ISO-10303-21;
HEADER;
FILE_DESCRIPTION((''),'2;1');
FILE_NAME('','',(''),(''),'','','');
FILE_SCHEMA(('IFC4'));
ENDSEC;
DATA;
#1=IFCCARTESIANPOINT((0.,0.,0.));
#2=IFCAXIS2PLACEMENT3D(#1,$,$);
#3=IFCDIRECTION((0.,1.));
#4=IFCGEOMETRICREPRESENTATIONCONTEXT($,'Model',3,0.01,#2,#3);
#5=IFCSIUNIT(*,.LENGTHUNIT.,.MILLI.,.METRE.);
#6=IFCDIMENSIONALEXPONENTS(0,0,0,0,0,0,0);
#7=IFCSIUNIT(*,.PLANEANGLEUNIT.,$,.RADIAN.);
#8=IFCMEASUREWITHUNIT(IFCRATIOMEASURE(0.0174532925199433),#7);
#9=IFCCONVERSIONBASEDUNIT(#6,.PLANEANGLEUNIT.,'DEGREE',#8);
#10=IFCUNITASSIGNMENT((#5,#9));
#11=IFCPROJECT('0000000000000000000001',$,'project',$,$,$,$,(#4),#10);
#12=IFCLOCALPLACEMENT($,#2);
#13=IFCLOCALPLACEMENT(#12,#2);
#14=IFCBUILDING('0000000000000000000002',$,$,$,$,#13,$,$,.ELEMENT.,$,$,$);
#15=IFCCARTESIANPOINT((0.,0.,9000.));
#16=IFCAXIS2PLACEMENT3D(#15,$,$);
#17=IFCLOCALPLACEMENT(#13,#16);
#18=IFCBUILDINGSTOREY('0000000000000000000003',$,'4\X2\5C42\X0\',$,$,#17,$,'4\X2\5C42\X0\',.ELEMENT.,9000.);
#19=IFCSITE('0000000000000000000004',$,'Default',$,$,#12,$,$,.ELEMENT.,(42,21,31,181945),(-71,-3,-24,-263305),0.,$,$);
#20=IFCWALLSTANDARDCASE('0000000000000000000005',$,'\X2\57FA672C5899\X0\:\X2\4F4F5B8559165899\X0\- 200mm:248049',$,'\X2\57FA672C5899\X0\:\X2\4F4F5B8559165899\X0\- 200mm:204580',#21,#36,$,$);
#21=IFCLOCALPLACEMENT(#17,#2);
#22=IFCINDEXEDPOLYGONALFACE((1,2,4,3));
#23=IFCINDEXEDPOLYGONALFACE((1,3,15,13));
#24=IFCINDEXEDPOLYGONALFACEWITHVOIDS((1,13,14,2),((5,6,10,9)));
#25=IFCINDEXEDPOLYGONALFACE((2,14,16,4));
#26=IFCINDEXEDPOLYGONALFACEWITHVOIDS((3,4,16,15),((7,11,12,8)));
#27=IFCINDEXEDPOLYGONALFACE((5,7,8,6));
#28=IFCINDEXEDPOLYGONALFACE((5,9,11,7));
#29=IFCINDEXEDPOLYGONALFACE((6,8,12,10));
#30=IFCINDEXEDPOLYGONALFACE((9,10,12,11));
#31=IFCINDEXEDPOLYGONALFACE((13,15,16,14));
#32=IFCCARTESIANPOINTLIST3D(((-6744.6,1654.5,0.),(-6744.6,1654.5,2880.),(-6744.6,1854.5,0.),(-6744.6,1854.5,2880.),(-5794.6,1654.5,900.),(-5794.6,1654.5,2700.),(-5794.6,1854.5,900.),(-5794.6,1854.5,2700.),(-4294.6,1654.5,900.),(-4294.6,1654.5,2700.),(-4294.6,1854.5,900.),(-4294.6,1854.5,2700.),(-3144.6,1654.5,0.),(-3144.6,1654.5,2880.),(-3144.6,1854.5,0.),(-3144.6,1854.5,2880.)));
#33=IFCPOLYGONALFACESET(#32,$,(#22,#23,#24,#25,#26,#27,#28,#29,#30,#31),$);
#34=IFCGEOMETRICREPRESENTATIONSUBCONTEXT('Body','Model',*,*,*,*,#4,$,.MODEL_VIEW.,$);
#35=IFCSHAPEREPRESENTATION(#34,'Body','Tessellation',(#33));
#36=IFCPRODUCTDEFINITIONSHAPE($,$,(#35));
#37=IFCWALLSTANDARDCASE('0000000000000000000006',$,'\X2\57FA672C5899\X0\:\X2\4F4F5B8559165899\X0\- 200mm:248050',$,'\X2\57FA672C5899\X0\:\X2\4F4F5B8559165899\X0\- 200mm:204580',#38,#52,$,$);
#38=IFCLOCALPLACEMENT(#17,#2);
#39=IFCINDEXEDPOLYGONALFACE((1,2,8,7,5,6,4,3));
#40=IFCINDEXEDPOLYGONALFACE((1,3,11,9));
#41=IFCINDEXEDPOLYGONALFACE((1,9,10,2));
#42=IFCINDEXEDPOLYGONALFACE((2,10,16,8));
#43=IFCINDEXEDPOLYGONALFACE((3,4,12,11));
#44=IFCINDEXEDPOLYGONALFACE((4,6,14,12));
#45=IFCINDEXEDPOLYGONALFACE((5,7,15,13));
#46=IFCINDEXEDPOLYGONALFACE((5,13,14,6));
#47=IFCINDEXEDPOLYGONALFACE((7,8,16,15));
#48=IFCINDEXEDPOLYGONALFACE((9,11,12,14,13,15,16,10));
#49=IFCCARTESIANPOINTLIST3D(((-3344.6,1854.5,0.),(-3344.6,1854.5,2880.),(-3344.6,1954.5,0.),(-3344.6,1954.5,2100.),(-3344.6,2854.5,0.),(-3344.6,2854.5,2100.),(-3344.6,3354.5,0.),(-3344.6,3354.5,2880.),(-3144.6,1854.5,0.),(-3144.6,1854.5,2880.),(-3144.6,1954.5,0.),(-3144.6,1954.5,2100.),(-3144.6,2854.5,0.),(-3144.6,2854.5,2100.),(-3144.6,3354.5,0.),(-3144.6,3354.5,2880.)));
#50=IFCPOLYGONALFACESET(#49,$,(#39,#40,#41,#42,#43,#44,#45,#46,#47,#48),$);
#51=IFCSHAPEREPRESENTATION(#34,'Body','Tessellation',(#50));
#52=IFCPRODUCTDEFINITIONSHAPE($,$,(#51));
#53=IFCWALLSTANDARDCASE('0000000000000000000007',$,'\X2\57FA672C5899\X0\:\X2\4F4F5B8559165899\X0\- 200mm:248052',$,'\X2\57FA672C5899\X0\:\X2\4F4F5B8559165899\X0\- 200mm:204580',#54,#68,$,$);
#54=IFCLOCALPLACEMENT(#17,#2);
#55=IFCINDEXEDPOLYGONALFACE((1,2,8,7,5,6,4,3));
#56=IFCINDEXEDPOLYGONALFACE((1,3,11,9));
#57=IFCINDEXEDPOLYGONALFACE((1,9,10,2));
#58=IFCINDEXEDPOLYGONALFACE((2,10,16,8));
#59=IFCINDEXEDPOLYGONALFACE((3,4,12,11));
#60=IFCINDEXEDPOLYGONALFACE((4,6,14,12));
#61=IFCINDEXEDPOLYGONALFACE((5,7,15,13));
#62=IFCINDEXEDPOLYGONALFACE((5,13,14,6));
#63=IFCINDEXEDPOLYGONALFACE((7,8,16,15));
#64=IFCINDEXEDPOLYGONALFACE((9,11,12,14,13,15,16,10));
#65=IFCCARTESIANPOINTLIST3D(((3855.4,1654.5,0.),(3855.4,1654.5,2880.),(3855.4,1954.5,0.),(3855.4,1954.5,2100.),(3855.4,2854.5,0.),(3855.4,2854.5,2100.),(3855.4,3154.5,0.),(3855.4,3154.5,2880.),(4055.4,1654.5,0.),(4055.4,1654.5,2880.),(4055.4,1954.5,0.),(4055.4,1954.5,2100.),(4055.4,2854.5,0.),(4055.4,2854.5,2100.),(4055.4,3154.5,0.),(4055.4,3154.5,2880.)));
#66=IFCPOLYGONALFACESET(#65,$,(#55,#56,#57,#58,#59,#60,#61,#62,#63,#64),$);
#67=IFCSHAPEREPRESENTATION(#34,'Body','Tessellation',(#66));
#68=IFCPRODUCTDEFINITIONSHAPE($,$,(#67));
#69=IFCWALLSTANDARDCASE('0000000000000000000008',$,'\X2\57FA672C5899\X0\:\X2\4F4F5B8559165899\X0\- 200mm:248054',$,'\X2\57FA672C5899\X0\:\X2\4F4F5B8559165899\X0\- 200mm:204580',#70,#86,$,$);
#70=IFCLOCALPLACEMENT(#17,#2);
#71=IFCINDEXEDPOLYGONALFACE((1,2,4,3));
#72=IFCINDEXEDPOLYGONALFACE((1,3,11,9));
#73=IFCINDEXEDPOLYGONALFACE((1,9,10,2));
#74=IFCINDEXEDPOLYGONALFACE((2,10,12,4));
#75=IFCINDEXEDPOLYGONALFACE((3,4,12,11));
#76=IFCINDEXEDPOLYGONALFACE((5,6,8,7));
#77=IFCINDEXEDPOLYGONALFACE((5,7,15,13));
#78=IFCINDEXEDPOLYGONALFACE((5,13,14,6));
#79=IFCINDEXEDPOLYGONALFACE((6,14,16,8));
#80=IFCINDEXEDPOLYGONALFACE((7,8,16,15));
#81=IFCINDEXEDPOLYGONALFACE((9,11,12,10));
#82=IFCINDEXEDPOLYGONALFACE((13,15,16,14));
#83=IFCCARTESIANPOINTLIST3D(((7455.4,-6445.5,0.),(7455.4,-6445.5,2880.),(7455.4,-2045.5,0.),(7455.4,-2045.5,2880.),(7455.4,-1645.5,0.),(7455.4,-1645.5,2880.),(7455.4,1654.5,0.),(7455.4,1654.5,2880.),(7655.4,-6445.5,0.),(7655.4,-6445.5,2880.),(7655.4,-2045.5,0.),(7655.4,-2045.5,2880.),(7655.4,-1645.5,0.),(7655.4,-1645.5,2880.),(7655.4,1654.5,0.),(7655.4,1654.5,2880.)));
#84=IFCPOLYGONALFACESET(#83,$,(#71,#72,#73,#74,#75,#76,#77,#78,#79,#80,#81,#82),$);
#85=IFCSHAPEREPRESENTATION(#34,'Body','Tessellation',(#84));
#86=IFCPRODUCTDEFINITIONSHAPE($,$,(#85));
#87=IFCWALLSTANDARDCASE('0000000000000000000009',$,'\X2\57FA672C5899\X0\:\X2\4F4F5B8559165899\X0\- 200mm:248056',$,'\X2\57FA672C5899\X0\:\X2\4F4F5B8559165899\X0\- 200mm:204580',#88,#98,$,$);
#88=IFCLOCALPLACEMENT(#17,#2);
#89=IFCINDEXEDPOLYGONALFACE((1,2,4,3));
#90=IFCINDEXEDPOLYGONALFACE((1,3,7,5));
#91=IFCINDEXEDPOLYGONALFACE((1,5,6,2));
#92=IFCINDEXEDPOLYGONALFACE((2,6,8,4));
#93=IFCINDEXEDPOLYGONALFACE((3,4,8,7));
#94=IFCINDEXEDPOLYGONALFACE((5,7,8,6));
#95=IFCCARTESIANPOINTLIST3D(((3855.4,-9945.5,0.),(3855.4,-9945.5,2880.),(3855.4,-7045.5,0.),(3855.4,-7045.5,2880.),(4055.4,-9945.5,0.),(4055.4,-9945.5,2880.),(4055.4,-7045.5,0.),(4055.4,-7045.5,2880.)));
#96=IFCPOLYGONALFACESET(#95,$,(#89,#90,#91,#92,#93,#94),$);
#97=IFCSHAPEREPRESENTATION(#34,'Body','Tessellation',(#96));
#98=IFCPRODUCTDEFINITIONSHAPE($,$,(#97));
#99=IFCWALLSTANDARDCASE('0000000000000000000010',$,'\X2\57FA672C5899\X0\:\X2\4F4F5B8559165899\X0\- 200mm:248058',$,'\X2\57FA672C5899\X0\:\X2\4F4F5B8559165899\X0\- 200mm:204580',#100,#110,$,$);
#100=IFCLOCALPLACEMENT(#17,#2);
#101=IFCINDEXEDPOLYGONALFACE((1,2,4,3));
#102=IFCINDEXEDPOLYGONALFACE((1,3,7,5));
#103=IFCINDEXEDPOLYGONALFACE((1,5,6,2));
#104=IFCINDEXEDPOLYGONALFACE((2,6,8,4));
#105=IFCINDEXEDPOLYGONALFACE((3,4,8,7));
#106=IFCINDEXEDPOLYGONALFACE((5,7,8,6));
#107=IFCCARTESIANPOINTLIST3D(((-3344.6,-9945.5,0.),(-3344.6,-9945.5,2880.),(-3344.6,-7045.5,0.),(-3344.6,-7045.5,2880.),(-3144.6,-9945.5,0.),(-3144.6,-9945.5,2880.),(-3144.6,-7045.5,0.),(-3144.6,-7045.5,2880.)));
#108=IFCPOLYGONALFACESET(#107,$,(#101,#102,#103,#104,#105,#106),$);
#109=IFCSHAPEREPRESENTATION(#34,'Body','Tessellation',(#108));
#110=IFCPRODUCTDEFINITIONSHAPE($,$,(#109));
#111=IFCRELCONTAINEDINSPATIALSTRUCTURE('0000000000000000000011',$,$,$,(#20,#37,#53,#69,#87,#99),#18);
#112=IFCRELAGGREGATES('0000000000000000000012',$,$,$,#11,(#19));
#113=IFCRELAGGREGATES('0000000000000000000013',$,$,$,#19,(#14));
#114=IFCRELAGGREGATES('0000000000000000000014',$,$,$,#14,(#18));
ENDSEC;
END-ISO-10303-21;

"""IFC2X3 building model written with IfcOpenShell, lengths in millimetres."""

from ifc_helpers import new_model, entity, si_unit, converted_unit, direction, frame, frame_2d, origin, place, context, subcontext, project, spatial, polyline, rectangle, extrude, clip, bounded_halfspace, element, save


model = new_model("IFC2X3")

# Units and contexts
model_context = context("Model", 3, precision=0.01, world=origin(), true_north=direction((0.0, 1.0)))
body_context = subcontext(model_context, "Body", "Model", "MODEL_VIEW")
ifc_project = project(units=[si_unit("LENGTHUNIT", "METRE", prefix="MILLI"), converted_unit("PLANEANGLEUNIT", "DEGREE", entity("IfcRatioMeasure", 0.0174532925199433), si_unit("PLANEANGLEUNIT", "RADIAN"), dimensions=[0, 0, 0, 0, 0, 0, 0])], contexts=[model_context])

# Site, building, storey
site_placement = place(None, origin())
site = spatial("IfcSite", under=ifc_project, at=site_placement, Name="Default", CompositionType="ELEMENT", RefLatitude=(42, 21, 31, 181945), RefLongitude=(-71, -3, -24, -263305), RefElevation=0.0)
building_placement = place(site_placement, origin())
building = spatial("IfcBuilding", under=site, at=building_placement, CompositionType="ELEMENT")
storey_placement = place(building_placement, frame((0.0, 0.0, 9000.0)))
storey = spatial("IfcBuildingStorey", under=building, at=storey_placement, Name="4层", LongName="4层", CompositionType="ELEMENT", Elevation=9000.0)

# Walls, openings
wall_1_placement = place(storey_placement, frame((-6744.6, 1754.5, 0.0)))
wall_1 = element("IfcWallStandardCase", 1, at=wall_1_placement, inside=storey, Name="基本墙:住宅外墙- 200mm:248049", ObjectType="基本墙:住宅外墙- 200mm:204580", context=body_context, shape_type="Clipping", body=[
    clip(extrude(rectangle(XDim=3600.0, YDim=200.0, at=frame_2d((1800.0, 0.0), x_axis=(-1.0, 0.0))), origin(), (0.0, 0.0, 1.0), 2880.0), bounded_halfspace(frame((0.0, -100.0, 2880.0), z_axis=(0.0, 0.0, -1.0), x_axis=(0.0, -1.0, 0.0)), True, frame((0.0, -100.0, 2880.0)), polyline([(0.0, 0.0), (3400.0, 0.0), (3600.0, 0.0), (3600.0, 200.0), (3400.0, 200.0), (0.0, 200.0), (0.0, 0.0)]))),
])
opening_1_placement = place(wall_1_placement, frame((950.0, -100.0, 900.0)))
element("IfcOpeningElement", 2, at=opening_1_placement, cuts=wall_1, ObjectType="Opening", context=body_context, shape_type="SweptSolid", body=[
    extrude(rectangle(XDim=1800.0, YDim=1500.0, at=frame_2d((900.0, 750.0), x_axis=(1.0, 0.0))), frame((0.0, 0.0, 0.0), z_axis=(0.0, 1.0, 0.0), x_axis=(0.0, 0.0, 1.0)), (0.0, 0.0, 1.0), 200.0),
])
wall_2_placement = place(storey_placement, frame((-3244.6, 1854.5, 0.0), z_axis=(0.0, 0.0, 1.0), x_axis=(0.0, 1.0, 0.0)))
wall_2 = element("IfcWallStandardCase", 3, at=wall_2_placement, inside=storey, Name="基本墙:住宅外墙- 200mm:248050", ObjectType="基本墙:住宅外墙- 200mm:204580", context=body_context, shape_type="Clipping", body=[
    clip(extrude(rectangle(XDim=1500.0, YDim=200.0, at=frame_2d((750.0, 0.0), x_axis=(-1.0, 0.0))), origin(), (0.0, 0.0, 1.0), 2880.0), bounded_halfspace(frame((0.0, -100.0, 2880.0), z_axis=(0.0, 0.0, -1.0), x_axis=(-1.0, 0.0, 0.0)), True, frame((0.0, -100.0, 2880.0)), polyline([(0.0, 0.0), (1300.0, 0.0), (1300.0, 200.0), (0.0, 200.0), (0.0, 0.0)]))),
])
opening_2_placement = place(wall_2_placement, frame((100.0, -100.0, 0.0)))
element("IfcOpeningElement", 4, at=opening_2_placement, cuts=wall_2, ObjectType="Opening", context=body_context, shape_type="SweptSolid", body=[
    extrude(rectangle(XDim=2100.0, YDim=900.0, at=frame_2d((1050.0, 450.0), x_axis=(1.0, 0.0))), frame((0.0, 0.0, 0.0), z_axis=(0.0, 1.0, 0.0), x_axis=(0.0, 0.0, 1.0)), (0.0, 0.0, 1.0), 200.0),
])
wall_3_placement = place(storey_placement, frame((3955.4, 3154.5, 0.0), z_axis=(0.0, 0.0, 1.0), x_axis=(0.0, -1.0, 0.0)))
wall_3 = element("IfcWallStandardCase", 5, at=wall_3_placement, inside=storey, Name="基本墙:住宅外墙- 200mm:248052", ObjectType="基本墙:住宅外墙- 200mm:204580", context=body_context, shape_type="Clipping", body=[
    clip(extrude(rectangle(XDim=1500.0, YDim=200.0, at=frame_2d((750.0, 0.0), x_axis=(-1.0, 0.0))), origin(), (0.0, 0.0, 1.0), 2880.0), bounded_halfspace(frame((0.0, -100.0, 2880.0), z_axis=(0.0, 0.0, -1.0), x_axis=(1.0, 0.0, 0.0)), True, frame((0.0, -100.0, 2880.0)), polyline([(0.0, 0.0), (1500.0, 0.0), (1500.0, 200.0), (0.0, 200.0), (0.0, 0.0)]))),
])
opening_3_placement = place(wall_3_placement, frame((300.0, -100.0, 0.0)))
element("IfcOpeningElement", 6, at=opening_3_placement, cuts=wall_3, ObjectType="Opening", context=body_context, shape_type="SweptSolid", body=[
    extrude(rectangle(XDim=2100.0, YDim=900.0, at=frame_2d((1050.0, 450.0), x_axis=(1.0, 0.0))), frame((0.0, 0.0, 0.0), z_axis=(0.0, 1.0, 0.0), x_axis=(0.0, 0.0, 1.0)), (0.0, 0.0, 1.0), 200.0),
])
wall_4_placement = place(storey_placement, frame((7555.4, 1654.5, 0.0), z_axis=(0.0, 0.0, 1.0), x_axis=(0.0, -1.0, 0.0)))
wall_4 = element("IfcWallStandardCase", 7, at=wall_4_placement, inside=storey, Name="基本墙:住宅外墙- 200mm:248054", ObjectType="基本墙:住宅外墙- 200mm:204580", context=body_context, shape_type="Clipping", body=[
    clip(extrude(rectangle(XDim=8100.0, YDim=200.0, at=frame_2d((4050.0, 0.0), x_axis=(-1.0, 0.0))), origin(), (0.0, 0.0, 1.0), 2880.0), bounded_halfspace(frame((8100.0, -100.0, 2880.0), z_axis=(1.0, 0.0, 0.0), x_axis=(0.0, 0.0, -1.0)), False, frame((8100.0, -100.0, 2880.0), z_axis=(1.0, 0.0, 0.0), x_axis=(0.0, 0.0, -1.0)), polyline([(0.0, 0.0), (2880.0, 0.0), (2880.0, 200.0), (0.0, 200.0), (0.0, 0.0)]))),
])
opening_4_placement = place(storey_placement, frame((7555.4, 1654.5, 0.0), z_axis=(0.0, 0.0, 1.0), x_axis=(0.0, -1.0, 0.0)))
element("IfcOpeningElement", 8, at=opening_4_placement, cuts=wall_4, ObjectType="Opening", context=body_context, shape_type="SweptSolid", body=[
    extrude(rectangle(XDim=2880.0, YDim=200.0, at=frame_2d((0.0, 0.0), x_axis=(1.0, 0.0))), frame((3700.0, 0.0, 1440.0), z_axis=(-1.0, 0.0, 0.0), x_axis=(0.0, 0.0, 1.0)), (0.0, 0.0, 1.0), 400.0),
])

# Walls
wall_5_placement = place(storey_placement, frame((3955.4, -7045.5, 0.0), z_axis=(0.0, 0.0, 1.0), x_axis=(0.0, -1.0, 0.0)))
element("IfcWallStandardCase", 9, at=wall_5_placement, inside=storey, Name="基本墙:住宅外墙- 200mm:248056", ObjectType="基本墙:住宅外墙- 200mm:204580", context=body_context, shape_type="Clipping", body=[
    clip(clip(clip(extrude(rectangle(XDim=2900.0, YDim=200.0, at=frame_2d((1450.0, 0.0), x_axis=(-1.0, 0.0))), origin(), (0.0, 0.0, 1.0), 2880.0), bounded_halfspace(frame((1400.0, -100.0, 2880.0), z_axis=(0.0, 0.0, -1.0), x_axis=(1.0, 0.0, 0.0)), True, frame((1400.0, -100.0, 2880.0)), polyline([(0.0, 0.0), (0.0, 200.0), (-1400.0, 200.0), (-1400.0, 0.0), (0.0, 0.0)]))), bounded_halfspace(frame((0.0, -100.0, 0.0), z_axis=(-1.0, 0.0, 0.0), x_axis=(0.0, 0.0, -1.0)), False, frame((0.0, -100.0, 0.0), z_axis=(-1.0, 0.0, 0.0), x_axis=(0.0, 0.0, -1.0)), polyline([(0.0, 0.0), (-2880.0, 0.0), (-2880.0, -200.0), (0.0, -200.0), (0.0, 0.0)]))), bounded_halfspace(frame((2900.0, -100.0, 2880.0), z_axis=(1.0, 0.0, 0.0), x_axis=(0.0, 0.0, -1.0)), False, frame((2900.0, -100.0, 2880.0), z_axis=(1.0, 0.0, 0.0), x_axis=(0.0, 0.0, -1.0)), polyline([(0.0, 0.0), (2880.0, 0.0), (2880.0, 200.0), (0.0, 200.0), (0.0, 0.0)]))),
])
wall_6_placement = place(storey_placement, frame((-3244.6, -9945.5, 0.0), z_axis=(0.0, 0.0, 1.0), x_axis=(0.0, 1.0, 0.0)))
element("IfcWallStandardCase", 10, at=wall_6_placement, inside=storey, Name="基本墙:住宅外墙- 200mm:248058", ObjectType="基本墙:住宅外墙- 200mm:204580", context=body_context, shape_type="Clipping", body=[
    clip(clip(clip(extrude(rectangle(XDim=2900.0, YDim=200.0, at=frame_2d((1450.0, 0.0), x_axis=(-1.0, 0.0))), origin(), (0.0, 0.0, 1.0), 2880.0), bounded_halfspace(frame((1500.0, 100.0, 2880.0), z_axis=(0.0, 0.0, -1.0), x_axis=(-1.0, 0.0, 0.0)), True, frame((1500.0, 100.0, 2880.0)), polyline([(0.0, 0.0), (0.0, -200.0), (1400.0, -200.0), (1400.0, 0.0), (0.0, 0.0)]))), bounded_halfspace(frame((0.0, -100.0, 0.0), z_axis=(1.0, 0.0, 0.0), x_axis=(0.0, 0.0, -1.0)), True, frame((0.0, -100.0, 0.0), z_axis=(1.0, 0.0, 0.0), x_axis=(0.0, 0.0, -1.0)), polyline([(0.0, 0.0), (0.0, 200.0), (-2880.0, 200.0), (-2880.0, 0.0), (0.0, 0.0)]))), bounded_halfspace(frame((2900.0, -100.0, 2880.0), z_axis=(-1.0, 0.0, 0.0), x_axis=(0.0, 0.0, -1.0)), True, frame((2900.0, -100.0, 2880.0), z_axis=(-1.0, 0.0, 0.0), x_axis=(0.0, 0.0, -1.0)), polyline([(0.0, 0.0), (0.0, -200.0), (2880.0, -200.0), (2880.0, 0.0), (0.0, 0.0)]))),
])

save(model, "model.ifc")
